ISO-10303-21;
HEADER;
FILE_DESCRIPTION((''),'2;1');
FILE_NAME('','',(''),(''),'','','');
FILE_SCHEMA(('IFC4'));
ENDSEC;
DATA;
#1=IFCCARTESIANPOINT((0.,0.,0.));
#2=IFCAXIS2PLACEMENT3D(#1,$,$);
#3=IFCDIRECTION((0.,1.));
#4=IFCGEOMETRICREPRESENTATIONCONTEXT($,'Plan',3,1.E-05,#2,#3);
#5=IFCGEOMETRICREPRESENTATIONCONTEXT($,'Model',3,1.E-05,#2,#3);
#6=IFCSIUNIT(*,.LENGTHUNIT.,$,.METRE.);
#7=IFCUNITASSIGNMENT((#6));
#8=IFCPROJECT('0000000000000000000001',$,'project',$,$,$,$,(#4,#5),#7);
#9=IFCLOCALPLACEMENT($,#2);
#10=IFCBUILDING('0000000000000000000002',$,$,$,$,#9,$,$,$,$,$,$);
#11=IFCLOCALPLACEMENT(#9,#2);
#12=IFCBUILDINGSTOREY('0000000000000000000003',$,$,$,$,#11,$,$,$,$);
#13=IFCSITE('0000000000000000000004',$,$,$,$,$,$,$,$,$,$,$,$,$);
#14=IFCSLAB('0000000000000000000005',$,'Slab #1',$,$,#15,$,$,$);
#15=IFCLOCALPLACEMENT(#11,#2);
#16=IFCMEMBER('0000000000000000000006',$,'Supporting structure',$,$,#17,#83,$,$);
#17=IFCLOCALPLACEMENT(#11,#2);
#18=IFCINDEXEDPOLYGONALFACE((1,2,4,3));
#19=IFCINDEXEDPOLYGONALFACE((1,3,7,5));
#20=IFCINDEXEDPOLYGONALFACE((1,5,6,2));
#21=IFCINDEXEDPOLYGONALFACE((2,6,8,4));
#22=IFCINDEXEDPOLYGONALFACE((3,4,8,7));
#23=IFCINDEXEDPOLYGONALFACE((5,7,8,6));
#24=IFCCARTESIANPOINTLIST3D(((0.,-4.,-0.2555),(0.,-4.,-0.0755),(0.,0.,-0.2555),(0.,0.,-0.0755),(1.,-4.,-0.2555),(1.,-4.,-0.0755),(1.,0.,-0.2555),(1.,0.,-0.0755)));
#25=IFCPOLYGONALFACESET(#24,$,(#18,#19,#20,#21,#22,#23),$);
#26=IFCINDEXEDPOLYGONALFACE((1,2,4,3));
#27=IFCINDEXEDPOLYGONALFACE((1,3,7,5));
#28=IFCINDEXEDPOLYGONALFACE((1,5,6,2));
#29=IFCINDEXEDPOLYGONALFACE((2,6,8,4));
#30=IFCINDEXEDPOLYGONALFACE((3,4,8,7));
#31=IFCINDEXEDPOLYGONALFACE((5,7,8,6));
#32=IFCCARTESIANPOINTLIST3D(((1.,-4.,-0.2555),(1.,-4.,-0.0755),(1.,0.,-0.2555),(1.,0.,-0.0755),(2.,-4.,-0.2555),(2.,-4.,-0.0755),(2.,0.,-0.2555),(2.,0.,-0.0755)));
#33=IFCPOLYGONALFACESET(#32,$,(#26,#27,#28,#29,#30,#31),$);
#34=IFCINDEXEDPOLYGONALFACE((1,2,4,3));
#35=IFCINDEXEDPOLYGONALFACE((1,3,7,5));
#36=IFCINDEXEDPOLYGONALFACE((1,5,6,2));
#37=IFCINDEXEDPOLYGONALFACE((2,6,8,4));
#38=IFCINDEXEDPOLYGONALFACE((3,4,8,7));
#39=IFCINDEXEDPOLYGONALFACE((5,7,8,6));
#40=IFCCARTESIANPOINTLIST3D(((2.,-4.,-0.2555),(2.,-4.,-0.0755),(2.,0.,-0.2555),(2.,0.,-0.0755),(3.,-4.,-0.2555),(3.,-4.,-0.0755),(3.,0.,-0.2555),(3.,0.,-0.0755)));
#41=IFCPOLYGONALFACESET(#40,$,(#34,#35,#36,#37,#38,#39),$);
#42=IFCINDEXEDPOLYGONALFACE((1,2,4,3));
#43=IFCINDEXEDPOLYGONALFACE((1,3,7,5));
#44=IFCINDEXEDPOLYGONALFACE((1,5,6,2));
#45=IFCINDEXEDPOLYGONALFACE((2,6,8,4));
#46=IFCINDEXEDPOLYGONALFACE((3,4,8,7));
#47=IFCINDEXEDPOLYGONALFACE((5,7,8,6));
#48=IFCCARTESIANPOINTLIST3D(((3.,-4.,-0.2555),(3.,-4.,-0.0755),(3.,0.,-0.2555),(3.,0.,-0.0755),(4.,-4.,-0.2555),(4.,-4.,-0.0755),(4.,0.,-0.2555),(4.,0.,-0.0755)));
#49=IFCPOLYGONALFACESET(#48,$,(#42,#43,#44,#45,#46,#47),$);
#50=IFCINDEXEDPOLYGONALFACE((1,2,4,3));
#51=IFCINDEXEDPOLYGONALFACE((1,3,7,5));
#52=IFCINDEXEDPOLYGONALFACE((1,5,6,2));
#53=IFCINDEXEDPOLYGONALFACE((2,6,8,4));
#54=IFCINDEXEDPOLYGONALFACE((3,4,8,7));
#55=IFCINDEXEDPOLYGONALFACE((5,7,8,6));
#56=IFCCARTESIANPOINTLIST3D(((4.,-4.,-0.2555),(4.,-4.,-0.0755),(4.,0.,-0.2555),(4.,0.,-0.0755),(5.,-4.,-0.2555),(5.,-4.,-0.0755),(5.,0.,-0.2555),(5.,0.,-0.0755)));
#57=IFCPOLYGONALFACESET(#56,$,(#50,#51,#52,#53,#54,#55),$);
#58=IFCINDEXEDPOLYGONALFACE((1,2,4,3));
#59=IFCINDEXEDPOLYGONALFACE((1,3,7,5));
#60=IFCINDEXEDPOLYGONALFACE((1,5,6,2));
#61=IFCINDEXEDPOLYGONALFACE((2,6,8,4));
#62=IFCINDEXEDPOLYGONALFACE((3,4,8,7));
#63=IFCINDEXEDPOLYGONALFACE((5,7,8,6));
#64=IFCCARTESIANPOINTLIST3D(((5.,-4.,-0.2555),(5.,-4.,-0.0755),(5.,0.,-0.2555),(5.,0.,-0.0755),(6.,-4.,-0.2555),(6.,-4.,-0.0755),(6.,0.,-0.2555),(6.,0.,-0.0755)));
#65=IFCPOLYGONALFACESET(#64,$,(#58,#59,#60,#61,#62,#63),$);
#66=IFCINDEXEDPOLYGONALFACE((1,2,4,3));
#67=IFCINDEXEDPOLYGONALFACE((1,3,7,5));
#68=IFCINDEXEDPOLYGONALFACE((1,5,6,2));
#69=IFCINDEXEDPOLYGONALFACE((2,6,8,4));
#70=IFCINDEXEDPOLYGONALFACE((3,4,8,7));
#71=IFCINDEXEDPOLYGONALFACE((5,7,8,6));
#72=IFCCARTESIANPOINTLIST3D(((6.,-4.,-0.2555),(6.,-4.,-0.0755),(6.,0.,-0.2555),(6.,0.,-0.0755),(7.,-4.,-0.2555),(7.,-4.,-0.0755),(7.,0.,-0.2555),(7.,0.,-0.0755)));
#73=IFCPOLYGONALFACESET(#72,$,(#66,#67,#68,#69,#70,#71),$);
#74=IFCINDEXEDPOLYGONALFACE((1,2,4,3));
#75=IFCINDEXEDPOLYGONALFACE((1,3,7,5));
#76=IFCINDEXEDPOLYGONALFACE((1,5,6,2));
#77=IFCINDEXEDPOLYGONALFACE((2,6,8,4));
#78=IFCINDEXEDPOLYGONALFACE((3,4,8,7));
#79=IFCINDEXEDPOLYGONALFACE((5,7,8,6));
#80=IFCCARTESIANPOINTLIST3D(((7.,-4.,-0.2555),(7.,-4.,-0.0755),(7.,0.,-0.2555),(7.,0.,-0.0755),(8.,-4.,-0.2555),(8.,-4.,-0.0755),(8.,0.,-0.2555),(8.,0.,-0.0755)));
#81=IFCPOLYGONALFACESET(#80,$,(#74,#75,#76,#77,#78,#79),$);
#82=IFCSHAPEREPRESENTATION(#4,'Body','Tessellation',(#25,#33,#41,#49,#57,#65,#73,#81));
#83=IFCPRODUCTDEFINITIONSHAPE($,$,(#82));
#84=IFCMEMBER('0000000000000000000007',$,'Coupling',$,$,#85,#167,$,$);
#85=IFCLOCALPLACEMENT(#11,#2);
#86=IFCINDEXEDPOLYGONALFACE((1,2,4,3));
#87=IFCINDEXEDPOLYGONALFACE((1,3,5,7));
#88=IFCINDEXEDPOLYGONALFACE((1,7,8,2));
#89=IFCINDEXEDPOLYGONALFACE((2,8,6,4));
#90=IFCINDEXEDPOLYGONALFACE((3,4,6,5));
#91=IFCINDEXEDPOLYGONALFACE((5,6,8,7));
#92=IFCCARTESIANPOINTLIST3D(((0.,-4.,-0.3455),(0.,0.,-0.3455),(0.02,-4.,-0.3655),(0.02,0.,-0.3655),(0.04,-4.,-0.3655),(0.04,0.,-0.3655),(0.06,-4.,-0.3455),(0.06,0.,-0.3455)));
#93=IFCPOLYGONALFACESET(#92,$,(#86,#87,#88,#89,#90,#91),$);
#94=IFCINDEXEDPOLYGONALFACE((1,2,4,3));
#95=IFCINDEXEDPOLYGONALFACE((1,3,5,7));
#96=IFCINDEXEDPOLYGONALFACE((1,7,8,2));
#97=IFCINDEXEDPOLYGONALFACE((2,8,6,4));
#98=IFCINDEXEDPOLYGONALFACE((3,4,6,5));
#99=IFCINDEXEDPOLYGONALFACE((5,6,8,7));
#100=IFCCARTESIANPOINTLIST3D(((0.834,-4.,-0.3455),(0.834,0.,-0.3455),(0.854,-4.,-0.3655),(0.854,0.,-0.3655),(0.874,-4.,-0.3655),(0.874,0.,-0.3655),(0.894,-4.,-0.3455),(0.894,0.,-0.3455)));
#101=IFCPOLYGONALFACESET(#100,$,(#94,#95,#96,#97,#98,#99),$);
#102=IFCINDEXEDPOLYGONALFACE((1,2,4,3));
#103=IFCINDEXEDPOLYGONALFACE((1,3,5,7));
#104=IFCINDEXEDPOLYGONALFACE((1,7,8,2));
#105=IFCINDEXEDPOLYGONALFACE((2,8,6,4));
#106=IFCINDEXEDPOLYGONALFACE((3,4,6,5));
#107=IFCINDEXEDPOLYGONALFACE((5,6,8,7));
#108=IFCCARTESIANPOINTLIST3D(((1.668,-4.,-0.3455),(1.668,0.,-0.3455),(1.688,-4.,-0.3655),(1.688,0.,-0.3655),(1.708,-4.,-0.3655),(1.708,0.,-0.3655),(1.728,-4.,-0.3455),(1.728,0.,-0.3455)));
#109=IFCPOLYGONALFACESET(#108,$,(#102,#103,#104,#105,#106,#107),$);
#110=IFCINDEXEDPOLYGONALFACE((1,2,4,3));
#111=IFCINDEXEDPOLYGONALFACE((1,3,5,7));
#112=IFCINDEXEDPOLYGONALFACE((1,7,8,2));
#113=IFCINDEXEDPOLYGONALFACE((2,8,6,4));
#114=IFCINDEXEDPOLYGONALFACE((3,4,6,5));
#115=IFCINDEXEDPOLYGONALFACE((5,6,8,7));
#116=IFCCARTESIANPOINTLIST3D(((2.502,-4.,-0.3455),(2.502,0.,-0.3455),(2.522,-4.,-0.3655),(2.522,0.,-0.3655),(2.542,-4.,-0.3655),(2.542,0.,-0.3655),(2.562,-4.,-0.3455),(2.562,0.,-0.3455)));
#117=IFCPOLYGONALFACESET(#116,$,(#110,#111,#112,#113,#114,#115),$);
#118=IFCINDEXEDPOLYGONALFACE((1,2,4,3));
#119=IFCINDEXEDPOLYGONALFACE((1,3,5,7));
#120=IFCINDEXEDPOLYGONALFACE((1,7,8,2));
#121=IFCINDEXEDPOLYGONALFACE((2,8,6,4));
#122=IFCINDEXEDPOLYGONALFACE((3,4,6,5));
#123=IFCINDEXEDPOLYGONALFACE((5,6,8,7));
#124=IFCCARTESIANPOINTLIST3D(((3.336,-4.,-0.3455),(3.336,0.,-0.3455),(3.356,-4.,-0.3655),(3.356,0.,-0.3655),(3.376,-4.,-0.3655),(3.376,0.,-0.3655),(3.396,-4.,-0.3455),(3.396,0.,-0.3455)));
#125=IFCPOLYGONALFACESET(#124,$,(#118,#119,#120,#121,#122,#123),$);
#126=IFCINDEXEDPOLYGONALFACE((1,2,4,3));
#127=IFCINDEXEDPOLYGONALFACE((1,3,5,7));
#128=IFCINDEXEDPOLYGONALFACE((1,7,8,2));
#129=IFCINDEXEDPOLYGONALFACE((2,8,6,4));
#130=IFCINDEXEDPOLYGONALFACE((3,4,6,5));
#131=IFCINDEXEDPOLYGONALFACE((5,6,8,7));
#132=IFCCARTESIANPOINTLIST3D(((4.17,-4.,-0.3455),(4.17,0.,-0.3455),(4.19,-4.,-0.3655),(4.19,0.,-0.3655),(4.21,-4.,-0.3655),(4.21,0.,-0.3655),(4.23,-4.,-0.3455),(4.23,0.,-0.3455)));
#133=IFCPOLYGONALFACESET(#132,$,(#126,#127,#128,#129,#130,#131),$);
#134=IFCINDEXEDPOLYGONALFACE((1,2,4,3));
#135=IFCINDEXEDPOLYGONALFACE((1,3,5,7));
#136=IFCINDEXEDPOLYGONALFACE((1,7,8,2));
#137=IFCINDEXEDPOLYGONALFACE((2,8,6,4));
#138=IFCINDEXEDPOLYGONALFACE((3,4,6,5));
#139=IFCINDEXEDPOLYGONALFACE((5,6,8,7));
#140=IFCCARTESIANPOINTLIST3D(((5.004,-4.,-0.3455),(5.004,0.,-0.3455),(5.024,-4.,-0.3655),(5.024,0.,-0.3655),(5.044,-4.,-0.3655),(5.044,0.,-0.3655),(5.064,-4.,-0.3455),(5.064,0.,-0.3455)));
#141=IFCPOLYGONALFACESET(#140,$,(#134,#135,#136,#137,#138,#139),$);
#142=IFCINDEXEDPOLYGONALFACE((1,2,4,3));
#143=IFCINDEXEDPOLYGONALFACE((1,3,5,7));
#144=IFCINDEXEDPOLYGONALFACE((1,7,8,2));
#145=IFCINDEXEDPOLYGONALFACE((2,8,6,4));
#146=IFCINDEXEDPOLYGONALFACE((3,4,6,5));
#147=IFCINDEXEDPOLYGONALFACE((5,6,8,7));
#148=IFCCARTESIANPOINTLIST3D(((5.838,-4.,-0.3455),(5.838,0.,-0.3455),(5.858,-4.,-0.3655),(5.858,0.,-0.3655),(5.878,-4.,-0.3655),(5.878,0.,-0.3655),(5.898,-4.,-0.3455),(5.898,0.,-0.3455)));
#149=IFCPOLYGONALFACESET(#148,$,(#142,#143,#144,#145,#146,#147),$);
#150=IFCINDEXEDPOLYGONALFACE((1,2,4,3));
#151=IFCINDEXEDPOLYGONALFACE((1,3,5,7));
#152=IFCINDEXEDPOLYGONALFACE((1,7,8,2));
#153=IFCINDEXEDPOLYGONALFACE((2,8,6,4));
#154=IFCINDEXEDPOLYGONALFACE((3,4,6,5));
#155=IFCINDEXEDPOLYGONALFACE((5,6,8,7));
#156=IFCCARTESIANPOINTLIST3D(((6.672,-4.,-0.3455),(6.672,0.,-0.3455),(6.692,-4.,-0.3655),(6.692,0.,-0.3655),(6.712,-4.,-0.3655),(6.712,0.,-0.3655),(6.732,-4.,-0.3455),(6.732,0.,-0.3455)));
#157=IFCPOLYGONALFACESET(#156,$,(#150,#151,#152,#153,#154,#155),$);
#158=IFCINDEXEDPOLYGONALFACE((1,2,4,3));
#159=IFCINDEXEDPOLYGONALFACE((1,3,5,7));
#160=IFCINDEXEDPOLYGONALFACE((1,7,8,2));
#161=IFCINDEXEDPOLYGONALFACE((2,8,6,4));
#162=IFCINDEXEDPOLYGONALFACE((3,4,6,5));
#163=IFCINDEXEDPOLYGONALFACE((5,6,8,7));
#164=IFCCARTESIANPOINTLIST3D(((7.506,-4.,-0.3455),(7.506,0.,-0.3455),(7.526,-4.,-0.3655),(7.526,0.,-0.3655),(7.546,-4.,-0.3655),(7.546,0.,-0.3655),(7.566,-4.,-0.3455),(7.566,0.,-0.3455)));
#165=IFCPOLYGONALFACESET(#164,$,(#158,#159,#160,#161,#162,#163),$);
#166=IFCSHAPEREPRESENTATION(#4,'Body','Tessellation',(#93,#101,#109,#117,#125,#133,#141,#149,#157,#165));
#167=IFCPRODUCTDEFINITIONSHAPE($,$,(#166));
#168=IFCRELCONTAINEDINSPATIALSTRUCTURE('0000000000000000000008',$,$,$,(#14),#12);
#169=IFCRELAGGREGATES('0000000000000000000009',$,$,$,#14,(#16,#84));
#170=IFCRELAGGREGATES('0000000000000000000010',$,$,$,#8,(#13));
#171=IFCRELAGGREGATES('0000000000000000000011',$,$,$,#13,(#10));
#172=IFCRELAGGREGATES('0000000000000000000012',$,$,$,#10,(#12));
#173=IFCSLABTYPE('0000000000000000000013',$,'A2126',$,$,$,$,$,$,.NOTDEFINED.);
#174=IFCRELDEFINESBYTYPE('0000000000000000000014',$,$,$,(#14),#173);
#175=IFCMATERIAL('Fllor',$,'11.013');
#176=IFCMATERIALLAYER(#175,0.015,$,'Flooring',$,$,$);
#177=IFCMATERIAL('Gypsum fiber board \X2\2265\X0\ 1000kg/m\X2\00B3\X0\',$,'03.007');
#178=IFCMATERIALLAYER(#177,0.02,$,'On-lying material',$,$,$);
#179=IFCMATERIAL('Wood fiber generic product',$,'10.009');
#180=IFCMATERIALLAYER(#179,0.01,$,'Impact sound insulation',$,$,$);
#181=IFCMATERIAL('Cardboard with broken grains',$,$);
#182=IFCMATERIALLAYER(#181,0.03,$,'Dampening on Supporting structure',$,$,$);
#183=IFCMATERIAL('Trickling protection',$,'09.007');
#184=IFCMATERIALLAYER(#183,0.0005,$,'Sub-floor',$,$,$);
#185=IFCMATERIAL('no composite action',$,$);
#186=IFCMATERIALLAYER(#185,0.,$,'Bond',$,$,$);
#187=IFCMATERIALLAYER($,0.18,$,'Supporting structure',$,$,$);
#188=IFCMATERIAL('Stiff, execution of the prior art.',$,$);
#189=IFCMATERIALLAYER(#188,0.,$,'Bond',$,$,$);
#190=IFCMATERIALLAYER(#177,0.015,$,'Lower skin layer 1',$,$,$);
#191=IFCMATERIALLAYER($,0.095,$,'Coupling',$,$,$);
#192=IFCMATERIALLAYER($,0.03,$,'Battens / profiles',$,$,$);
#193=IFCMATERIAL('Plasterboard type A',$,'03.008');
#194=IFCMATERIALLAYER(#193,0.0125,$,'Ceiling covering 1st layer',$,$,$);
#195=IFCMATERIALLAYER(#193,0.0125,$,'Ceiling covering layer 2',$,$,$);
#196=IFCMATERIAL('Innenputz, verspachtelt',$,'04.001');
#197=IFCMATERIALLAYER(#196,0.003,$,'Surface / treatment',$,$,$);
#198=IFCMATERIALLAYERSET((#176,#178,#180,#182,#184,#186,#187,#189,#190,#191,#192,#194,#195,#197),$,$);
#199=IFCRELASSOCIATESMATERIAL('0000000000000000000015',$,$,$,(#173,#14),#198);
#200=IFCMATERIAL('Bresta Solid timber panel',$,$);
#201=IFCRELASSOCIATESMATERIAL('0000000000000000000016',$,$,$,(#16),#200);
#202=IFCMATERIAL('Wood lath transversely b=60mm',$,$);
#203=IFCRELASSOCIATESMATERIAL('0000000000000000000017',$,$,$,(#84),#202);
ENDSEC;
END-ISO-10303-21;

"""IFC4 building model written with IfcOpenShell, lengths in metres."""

from ifc_helpers import new_model, si_unit, direction, frame, frame_2d, origin, place, context, project, spatial, polyline, rectangle, outline, extrude, material, layer, layer_set, type_object, element, aggregate, save


model = new_model("IFC4")

# Units and contexts
plan_context = context("Plan", 3, precision=1e-05, world=origin(), true_north=direction((0.0, 1.0)))
model_context = context("Model", 3, precision=1e-05, world=origin(), true_north=direction((0.0, 1.0)))
ifc_project = project(units=[si_unit("LENGTHUNIT", "METRE")], contexts=[plan_context, model_context])

# Site, building, storey
site = spatial("IfcSite", under=ifc_project)
building_placement = place(None, origin())
building = spatial("IfcBuilding", under=site, at=building_placement)
storey_placement = place(building_placement, origin())
storey = spatial("IfcBuildingStorey", under=building, at=storey_placement)

# Slab, members
ifc_material_1 = material(Name="Fllor", Category="11.013")
ifc_layer_1 = layer(ifc_material_1, 0.015, Name="Flooring")
ifc_material_2 = material(Name="Gypsum fiber board ≥ 1000kg/m³", Category="03.007")
ifc_layer_2 = layer(ifc_material_2, 0.02, Name="On-lying material")
ifc_material_3 = material(Name="Wood fiber generic product", Category="10.009")
ifc_layer_3 = layer(ifc_material_3, 0.01, Name="Impact sound insulation")
ifc_material_4 = material(Name="Cardboard with broken grains")
ifc_layer_4 = layer(ifc_material_4, 0.03, Name="Dampening on Supporting structure")
ifc_material_5 = material(Name="Trickling protection", Category="09.007")
ifc_layer_5 = layer(ifc_material_5, 0.0005, Name="Sub-floor")
ifc_material_6 = material(Name="no composite action")
ifc_layer_6 = layer(ifc_material_6, 0.0, Name="Bond")
ifc_layer_7 = layer(None, 0.18, Name="Supporting structure")
ifc_material_7 = material(Name="Stiff, execution of the prior art.")
ifc_layer_8 = layer(ifc_material_7, 0.0, Name="Bond")
ifc_layer_9 = layer(ifc_material_2, 0.015, Name="Lower skin layer 1")
ifc_layer_10 = layer(None, 0.095, Name="Coupling")
ifc_layer_11 = layer(None, 0.03, Name="Battens / profiles")
ifc_material_8 = material(Name="Plasterboard type A", Category="03.008")
ifc_layer_12 = layer(ifc_material_8, 0.0125, Name="Ceiling covering 1st layer")
ifc_layer_13 = layer(ifc_material_8, 0.0125, Name="Ceiling covering layer 2")
ifc_material_9 = material(Name="Innenputz, verspachtelt", Category="04.001")
ifc_layer_14 = layer(ifc_material_9, 0.003, Name="Surface / treatment")
ifc_layer_set = layer_set([ifc_layer_1, ifc_layer_2, ifc_layer_3, ifc_layer_4, ifc_layer_5, ifc_layer_6, ifc_layer_7, ifc_layer_8, ifc_layer_9, ifc_layer_10, ifc_layer_11, ifc_layer_12, ifc_layer_13, ifc_layer_14])
slab_type = type_object("IfcSlabType", Name="A2126", PredefinedType="NOTDEFINED", material=ifc_layer_set)
slab_placement = place(None, frame((0.0, 0.0, 0.0), z_axis=(0.0, 0.0, -1.0), x_axis=(1.0, 0.0, 0.0)))
slab = element("IfcSlab", 1, at=slab_placement, inside=storey, type_object=slab_type, material=ifc_layer_set, Name="Slab #1")
ifc_material_10 = material(Name="Bresta Solid timber panel")
member_1_placement = place(slab_placement, origin())
member_1 = element("IfcMember", 2, at=member_1_placement, material=ifc_material_10, Name="Supporting structure", context=plan_context, shape_type="SweptSolid", body=[
    extrude(rectangle(XDim=1.0, YDim=0.18, at=frame_2d((0.5, 0.09), x_axis=(1.0, 0.0))), frame((0.0, 4.0, 0.0755), z_axis=(0.0, -1.0, 0.0), x_axis=(1.0, 0.0, 0.0)), (0.0, 0.0, 1.0), 4.0),
    extrude(rectangle(XDim=1.0, YDim=0.18, at=frame_2d((0.5, 0.09), x_axis=(1.0, 0.0))), frame((1.0, 4.0, 0.0755), z_axis=(0.0, -1.0, 0.0), x_axis=(1.0, 0.0, 0.0)), (0.0, 0.0, 1.0), 4.0),
    extrude(rectangle(XDim=1.0, YDim=0.18, at=frame_2d((0.5, 0.09), x_axis=(1.0, 0.0))), frame((2.0, 4.0, 0.0755), z_axis=(0.0, -1.0, 0.0), x_axis=(1.0, 0.0, 0.0)), (0.0, 0.0, 1.0), 4.0),
    extrude(rectangle(XDim=1.0, YDim=0.18, at=frame_2d((0.5, 0.09), x_axis=(1.0, 0.0))), frame((3.0, 4.0, 0.0755), z_axis=(0.0, -1.0, 0.0), x_axis=(1.0, 0.0, 0.0)), (0.0, 0.0, 1.0), 4.0),
    extrude(rectangle(XDim=1.0, YDim=0.18, at=frame_2d((0.5, 0.09), x_axis=(1.0, 0.0))), frame((4.0, 4.0, 0.0755), z_axis=(0.0, -1.0, 0.0), x_axis=(1.0, 0.0, 0.0)), (0.0, 0.0, 1.0), 4.0),
    extrude(rectangle(XDim=1.0, YDim=0.18, at=frame_2d((0.5, 0.09), x_axis=(1.0, 0.0))), frame((5.0, 4.0, 0.0755), z_axis=(0.0, -1.0, 0.0), x_axis=(1.0, 0.0, 0.0)), (0.0, 0.0, 1.0), 4.0),
    extrude(rectangle(XDim=1.0, YDim=0.18, at=frame_2d((0.5, 0.09), x_axis=(1.0, 0.0))), frame((6.0, 4.0, 0.0755), z_axis=(0.0, -1.0, 0.0), x_axis=(1.0, 0.0, 0.0)), (0.0, 0.0, 1.0), 4.0),
    extrude(rectangle(XDim=1.0, YDim=0.18, at=frame_2d((0.5, 0.09), x_axis=(1.0, 0.0))), frame((7.0, 4.0, 0.0755), z_axis=(0.0, -1.0, 0.0), x_axis=(1.0, 0.0, 0.0)), (0.0, 0.0, 1.0), 4.0),
])
ifc_material_11 = material(Name="Wood lath transversely b=60mm")
member_2_placement = place(slab_placement, origin())
member_2 = element("IfcMember", 3, at=member_2_placement, material=ifc_material_11, Name="Coupling", context=plan_context, shape_type="SweptSolid", body=[
    extrude(outline(polyline([(0.0, 0.0), (0.06, 0.0), (0.04, 0.02), (0.02, 0.02), (0.0, 0.0)])), frame((0.0, 4.0, 0.3455), z_axis=(0.0, -1.0, 0.0), x_axis=(1.0, 0.0, 0.0)), (0.0, 0.0, 1.0), 4.0),
    extrude(outline(polyline([(0.0, 0.0), (0.06, 0.0), (0.04, 0.02), (0.02, 0.02), (0.0, 0.0)])), frame((0.834, 4.0, 0.3455), z_axis=(0.0, -1.0, 0.0), x_axis=(1.0, 0.0, 0.0)), (0.0, 0.0, 1.0), 4.0),
    extrude(outline(polyline([(0.0, 0.0), (0.06, 0.0), (0.04, 0.02), (0.02, 0.02), (0.0, 0.0)])), frame((1.668, 4.0, 0.3455), z_axis=(0.0, -1.0, 0.0), x_axis=(1.0, 0.0, 0.0)), (0.0, 0.0, 1.0), 4.0),
    extrude(outline(polyline([(0.0, 0.0), (0.06, 0.0), (0.04, 0.02), (0.02, 0.02), (0.0, 0.0)])), frame((2.502, 4.0, 0.3455), z_axis=(0.0, -1.0, 0.0), x_axis=(1.0, 0.0, 0.0)), (0.0, 0.0, 1.0), 4.0),
    extrude(outline(polyline([(0.0, 0.0), (0.06, 0.0), (0.04, 0.02), (0.02, 0.02), (0.0, 0.0)])), frame((3.336, 4.0, 0.3455), z_axis=(0.0, -1.0, 0.0), x_axis=(1.0, 0.0, 0.0)), (0.0, 0.0, 1.0), 4.0),
    extrude(outline(polyline([(0.0, 0.0), (0.06, 0.0), (0.04, 0.02), (0.02, 0.02), (0.0, 0.0)])), frame((4.17, 4.0, 0.3455), z_axis=(0.0, -1.0, 0.0), x_axis=(1.0, 0.0, 0.0)), (0.0, 0.0, 1.0), 4.0),
    extrude(outline(polyline([(0.0, 0.0), (0.06, 0.0), (0.04, 0.02), (0.02, 0.02), (0.0, 0.0)])), frame((5.004, 4.0, 0.3455), z_axis=(0.0, -1.0, 0.0), x_axis=(1.0, 0.0, 0.0)), (0.0, 0.0, 1.0), 4.0),
    extrude(outline(polyline([(0.0, 0.0), (0.06, 0.0), (0.04, 0.02), (0.02, 0.02), (0.0, 0.0)])), frame((5.838, 4.0, 0.3455), z_axis=(0.0, -1.0, 0.0), x_axis=(1.0, 0.0, 0.0)), (0.0, 0.0, 1.0), 4.0),
    extrude(outline(polyline([(0.0, 0.0), (0.06, 0.0), (0.04, 0.02), (0.02, 0.02), (0.0, 0.0)])), frame((6.672, 4.0, 0.3455), z_axis=(0.0, -1.0, 0.0), x_axis=(1.0, 0.0, 0.0)), (0.0, 0.0, 1.0), 4.0),
    extrude(outline(polyline([(0.0, 0.0), (0.06, 0.0), (0.04, 0.02), (0.02, 0.02), (0.0, 0.0)])), frame((7.506, 4.0, 0.3455), z_axis=(0.0, -1.0, 0.0), x_axis=(1.0, 0.0, 0.0)), (0.0, 0.0, 1.0), 4.0),
])
aggregate(slab, [member_1, member_2])

save(model, "model.ifc")
